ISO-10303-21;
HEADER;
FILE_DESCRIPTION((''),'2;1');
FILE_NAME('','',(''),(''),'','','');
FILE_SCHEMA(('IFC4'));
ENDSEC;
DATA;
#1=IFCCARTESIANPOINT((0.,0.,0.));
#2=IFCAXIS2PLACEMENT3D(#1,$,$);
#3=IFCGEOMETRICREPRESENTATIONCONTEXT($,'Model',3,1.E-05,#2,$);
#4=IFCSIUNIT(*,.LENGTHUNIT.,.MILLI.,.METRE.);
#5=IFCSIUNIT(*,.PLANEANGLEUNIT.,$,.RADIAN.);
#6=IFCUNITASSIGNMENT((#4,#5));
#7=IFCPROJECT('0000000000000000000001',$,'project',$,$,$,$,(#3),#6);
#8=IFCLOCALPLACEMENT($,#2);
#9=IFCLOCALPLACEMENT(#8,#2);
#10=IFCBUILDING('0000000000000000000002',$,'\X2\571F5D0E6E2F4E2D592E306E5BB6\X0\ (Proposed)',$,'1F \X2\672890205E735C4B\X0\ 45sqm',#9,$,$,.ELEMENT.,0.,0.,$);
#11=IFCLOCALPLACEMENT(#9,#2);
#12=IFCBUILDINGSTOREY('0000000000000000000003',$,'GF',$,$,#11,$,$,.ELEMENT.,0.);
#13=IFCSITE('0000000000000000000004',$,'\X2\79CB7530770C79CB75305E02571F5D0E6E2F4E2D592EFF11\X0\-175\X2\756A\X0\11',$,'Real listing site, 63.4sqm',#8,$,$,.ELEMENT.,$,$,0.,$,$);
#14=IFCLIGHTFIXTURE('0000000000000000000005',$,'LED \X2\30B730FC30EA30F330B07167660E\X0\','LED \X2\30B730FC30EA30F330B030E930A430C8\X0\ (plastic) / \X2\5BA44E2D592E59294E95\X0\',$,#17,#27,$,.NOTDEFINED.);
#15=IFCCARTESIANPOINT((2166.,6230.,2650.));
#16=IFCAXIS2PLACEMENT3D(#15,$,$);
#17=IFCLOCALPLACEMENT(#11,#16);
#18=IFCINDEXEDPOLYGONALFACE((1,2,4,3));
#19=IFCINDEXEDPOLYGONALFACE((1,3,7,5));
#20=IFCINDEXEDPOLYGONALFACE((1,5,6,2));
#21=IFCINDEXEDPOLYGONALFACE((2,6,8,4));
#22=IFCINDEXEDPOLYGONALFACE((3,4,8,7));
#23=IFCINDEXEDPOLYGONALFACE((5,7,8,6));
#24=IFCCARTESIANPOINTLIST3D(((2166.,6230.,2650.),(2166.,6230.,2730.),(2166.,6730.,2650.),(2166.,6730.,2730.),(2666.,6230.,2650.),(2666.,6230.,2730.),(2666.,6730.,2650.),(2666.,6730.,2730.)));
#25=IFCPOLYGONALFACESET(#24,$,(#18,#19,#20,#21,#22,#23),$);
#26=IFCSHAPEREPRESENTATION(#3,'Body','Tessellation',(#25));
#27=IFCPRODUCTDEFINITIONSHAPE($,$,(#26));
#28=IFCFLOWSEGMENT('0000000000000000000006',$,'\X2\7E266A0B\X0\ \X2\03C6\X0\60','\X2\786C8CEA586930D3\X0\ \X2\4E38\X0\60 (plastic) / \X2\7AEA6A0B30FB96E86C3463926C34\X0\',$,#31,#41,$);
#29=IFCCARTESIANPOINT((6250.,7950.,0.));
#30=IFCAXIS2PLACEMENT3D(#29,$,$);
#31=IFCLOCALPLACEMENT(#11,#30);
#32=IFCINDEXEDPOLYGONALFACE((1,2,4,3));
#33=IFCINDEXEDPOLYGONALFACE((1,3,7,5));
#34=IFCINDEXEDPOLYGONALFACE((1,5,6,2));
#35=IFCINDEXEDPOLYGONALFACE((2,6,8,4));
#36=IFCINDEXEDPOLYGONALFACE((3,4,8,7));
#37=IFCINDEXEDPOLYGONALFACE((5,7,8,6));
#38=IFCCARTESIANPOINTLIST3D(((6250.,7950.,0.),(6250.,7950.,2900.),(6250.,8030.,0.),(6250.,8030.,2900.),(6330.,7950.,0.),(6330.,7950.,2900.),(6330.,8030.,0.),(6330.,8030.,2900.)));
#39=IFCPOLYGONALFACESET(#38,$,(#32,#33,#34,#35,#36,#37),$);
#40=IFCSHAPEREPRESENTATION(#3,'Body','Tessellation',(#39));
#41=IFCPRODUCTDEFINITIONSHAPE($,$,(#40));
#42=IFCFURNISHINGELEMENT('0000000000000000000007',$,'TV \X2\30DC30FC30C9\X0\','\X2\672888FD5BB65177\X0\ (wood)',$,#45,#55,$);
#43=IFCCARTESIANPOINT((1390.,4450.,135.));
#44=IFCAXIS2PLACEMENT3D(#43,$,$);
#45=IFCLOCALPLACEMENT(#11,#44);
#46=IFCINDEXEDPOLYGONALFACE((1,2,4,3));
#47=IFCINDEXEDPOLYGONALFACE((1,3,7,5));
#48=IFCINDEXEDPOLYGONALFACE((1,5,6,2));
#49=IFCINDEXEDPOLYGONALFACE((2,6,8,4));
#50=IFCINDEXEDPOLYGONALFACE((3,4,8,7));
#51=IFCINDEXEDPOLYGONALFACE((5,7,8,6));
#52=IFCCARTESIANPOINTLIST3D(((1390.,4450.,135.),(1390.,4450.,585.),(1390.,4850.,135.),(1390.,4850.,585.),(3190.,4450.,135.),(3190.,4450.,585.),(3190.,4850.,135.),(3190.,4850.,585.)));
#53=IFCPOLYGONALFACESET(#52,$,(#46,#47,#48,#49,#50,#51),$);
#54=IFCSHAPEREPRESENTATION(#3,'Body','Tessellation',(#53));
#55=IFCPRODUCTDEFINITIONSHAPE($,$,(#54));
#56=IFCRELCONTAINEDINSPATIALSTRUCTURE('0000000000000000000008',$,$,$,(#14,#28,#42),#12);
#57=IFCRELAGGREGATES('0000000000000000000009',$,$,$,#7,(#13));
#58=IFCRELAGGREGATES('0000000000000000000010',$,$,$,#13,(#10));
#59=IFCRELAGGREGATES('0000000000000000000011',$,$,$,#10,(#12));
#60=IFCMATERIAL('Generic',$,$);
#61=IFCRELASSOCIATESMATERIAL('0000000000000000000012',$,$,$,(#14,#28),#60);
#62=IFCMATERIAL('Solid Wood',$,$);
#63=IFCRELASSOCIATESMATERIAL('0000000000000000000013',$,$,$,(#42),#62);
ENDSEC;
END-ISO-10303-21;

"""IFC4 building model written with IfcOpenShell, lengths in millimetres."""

from ifc_helpers import new_model, si_unit, frame, frame_2d, origin, place, context, project, spatial, rectangle, extrude, material, element, save


model = new_model("IFC4")

# Units and contexts
model_context = context("Model", 3, precision=1e-05, world=origin())
ifc_project = project(units=[si_unit("LENGTHUNIT", "METRE", prefix="MILLI"), si_unit("PLANEANGLEUNIT", "RADIAN")], contexts=[model_context])

# Site, building, storey
site_placement = place(None, origin())
site = spatial("IfcSite", under=ifc_project, at=site_placement, Name="秋田県秋田市土崎港中央１-175番11", ObjectType="Real listing site, 63.4sqm", CompositionType="ELEMENT", RefElevation=0.0)
building_placement = place(site_placement, origin())
building = spatial("IfcBuilding", under=site, at=building_placement, Name="土崎港中央の家 (Proposed)", ObjectType="1F 木造平屋 45sqm", CompositionType="ELEMENT", ElevationOfRefHeight=0.0, ElevationOfTerrain=0.0)
storey_placement = place(building_placement, origin())
storey = spatial("IfcBuildingStorey", under=building, at=storey_placement, Name="GF", CompositionType="ELEMENT", Elevation=0.0)

# Shared definitions
ifc_material_1 = material(Name="Solid Wood")

# Shared definitions
ifc_material_2 = material(Name="Generic")

# Light fixture
light_fixture_1_placement = place(storey_placement, frame((2166.0, 6230.0, 2650.0)))
element("IfcLightFixture", 1, at=light_fixture_1_placement, inside=storey, material=ifc_material_2, Name="LED シーリング照明", Description="LED シーリングライト (plastic) / 室中央天井", PredefinedType="NOTDEFINED", context=model_context, shape_type="SweptSolid", body=[
    extrude(rectangle(XDim=500.0, YDim=500.0, at=frame_2d((250.0, 250.0))), frame((2166.0, 6230.0, 2650.0)), (0.0, 0.0, 1.0), 80.0),
])

# Flow segment
flow_segment_placement = place(storey_placement, frame((6250.0, 7950.0, 0.0)))
element("IfcFlowSegment", 2, at=flow_segment_placement, inside=storey, material=ifc_material_2, Name="縦樋 φ60", Description="硬質塩ビ 丸60 (plastic) / 竪樋・雨水排水", context=model_context, shape_type="SweptSolid", body=[
    extrude(rectangle(XDim=80.0, YDim=80.0, at=frame_2d((40.0, 40.0))), frame((6250.0, 7950.0, 0.0)), (0.0, 0.0, 1.0), 2900.0),
])

# Furnishing element
furnishing_placement = place(storey_placement, frame((1390.0, 4450.0, 135.0)))
element("IfcFurnishingElement", 3, at=furnishing_placement, inside=storey, material=ifc_material_1, Name="TV ボード", Description="木製家具 (wood)", context=model_context, shape_type="SweptSolid", body=[
    extrude(rectangle(XDim=1800.0, YDim=400.0, at=frame_2d((900.0, 200.0))), frame((1390.0, 4450.0, 135.0)), (0.0, 0.0, 1.0), 450.0),
])

save(model, "model.ifc")
